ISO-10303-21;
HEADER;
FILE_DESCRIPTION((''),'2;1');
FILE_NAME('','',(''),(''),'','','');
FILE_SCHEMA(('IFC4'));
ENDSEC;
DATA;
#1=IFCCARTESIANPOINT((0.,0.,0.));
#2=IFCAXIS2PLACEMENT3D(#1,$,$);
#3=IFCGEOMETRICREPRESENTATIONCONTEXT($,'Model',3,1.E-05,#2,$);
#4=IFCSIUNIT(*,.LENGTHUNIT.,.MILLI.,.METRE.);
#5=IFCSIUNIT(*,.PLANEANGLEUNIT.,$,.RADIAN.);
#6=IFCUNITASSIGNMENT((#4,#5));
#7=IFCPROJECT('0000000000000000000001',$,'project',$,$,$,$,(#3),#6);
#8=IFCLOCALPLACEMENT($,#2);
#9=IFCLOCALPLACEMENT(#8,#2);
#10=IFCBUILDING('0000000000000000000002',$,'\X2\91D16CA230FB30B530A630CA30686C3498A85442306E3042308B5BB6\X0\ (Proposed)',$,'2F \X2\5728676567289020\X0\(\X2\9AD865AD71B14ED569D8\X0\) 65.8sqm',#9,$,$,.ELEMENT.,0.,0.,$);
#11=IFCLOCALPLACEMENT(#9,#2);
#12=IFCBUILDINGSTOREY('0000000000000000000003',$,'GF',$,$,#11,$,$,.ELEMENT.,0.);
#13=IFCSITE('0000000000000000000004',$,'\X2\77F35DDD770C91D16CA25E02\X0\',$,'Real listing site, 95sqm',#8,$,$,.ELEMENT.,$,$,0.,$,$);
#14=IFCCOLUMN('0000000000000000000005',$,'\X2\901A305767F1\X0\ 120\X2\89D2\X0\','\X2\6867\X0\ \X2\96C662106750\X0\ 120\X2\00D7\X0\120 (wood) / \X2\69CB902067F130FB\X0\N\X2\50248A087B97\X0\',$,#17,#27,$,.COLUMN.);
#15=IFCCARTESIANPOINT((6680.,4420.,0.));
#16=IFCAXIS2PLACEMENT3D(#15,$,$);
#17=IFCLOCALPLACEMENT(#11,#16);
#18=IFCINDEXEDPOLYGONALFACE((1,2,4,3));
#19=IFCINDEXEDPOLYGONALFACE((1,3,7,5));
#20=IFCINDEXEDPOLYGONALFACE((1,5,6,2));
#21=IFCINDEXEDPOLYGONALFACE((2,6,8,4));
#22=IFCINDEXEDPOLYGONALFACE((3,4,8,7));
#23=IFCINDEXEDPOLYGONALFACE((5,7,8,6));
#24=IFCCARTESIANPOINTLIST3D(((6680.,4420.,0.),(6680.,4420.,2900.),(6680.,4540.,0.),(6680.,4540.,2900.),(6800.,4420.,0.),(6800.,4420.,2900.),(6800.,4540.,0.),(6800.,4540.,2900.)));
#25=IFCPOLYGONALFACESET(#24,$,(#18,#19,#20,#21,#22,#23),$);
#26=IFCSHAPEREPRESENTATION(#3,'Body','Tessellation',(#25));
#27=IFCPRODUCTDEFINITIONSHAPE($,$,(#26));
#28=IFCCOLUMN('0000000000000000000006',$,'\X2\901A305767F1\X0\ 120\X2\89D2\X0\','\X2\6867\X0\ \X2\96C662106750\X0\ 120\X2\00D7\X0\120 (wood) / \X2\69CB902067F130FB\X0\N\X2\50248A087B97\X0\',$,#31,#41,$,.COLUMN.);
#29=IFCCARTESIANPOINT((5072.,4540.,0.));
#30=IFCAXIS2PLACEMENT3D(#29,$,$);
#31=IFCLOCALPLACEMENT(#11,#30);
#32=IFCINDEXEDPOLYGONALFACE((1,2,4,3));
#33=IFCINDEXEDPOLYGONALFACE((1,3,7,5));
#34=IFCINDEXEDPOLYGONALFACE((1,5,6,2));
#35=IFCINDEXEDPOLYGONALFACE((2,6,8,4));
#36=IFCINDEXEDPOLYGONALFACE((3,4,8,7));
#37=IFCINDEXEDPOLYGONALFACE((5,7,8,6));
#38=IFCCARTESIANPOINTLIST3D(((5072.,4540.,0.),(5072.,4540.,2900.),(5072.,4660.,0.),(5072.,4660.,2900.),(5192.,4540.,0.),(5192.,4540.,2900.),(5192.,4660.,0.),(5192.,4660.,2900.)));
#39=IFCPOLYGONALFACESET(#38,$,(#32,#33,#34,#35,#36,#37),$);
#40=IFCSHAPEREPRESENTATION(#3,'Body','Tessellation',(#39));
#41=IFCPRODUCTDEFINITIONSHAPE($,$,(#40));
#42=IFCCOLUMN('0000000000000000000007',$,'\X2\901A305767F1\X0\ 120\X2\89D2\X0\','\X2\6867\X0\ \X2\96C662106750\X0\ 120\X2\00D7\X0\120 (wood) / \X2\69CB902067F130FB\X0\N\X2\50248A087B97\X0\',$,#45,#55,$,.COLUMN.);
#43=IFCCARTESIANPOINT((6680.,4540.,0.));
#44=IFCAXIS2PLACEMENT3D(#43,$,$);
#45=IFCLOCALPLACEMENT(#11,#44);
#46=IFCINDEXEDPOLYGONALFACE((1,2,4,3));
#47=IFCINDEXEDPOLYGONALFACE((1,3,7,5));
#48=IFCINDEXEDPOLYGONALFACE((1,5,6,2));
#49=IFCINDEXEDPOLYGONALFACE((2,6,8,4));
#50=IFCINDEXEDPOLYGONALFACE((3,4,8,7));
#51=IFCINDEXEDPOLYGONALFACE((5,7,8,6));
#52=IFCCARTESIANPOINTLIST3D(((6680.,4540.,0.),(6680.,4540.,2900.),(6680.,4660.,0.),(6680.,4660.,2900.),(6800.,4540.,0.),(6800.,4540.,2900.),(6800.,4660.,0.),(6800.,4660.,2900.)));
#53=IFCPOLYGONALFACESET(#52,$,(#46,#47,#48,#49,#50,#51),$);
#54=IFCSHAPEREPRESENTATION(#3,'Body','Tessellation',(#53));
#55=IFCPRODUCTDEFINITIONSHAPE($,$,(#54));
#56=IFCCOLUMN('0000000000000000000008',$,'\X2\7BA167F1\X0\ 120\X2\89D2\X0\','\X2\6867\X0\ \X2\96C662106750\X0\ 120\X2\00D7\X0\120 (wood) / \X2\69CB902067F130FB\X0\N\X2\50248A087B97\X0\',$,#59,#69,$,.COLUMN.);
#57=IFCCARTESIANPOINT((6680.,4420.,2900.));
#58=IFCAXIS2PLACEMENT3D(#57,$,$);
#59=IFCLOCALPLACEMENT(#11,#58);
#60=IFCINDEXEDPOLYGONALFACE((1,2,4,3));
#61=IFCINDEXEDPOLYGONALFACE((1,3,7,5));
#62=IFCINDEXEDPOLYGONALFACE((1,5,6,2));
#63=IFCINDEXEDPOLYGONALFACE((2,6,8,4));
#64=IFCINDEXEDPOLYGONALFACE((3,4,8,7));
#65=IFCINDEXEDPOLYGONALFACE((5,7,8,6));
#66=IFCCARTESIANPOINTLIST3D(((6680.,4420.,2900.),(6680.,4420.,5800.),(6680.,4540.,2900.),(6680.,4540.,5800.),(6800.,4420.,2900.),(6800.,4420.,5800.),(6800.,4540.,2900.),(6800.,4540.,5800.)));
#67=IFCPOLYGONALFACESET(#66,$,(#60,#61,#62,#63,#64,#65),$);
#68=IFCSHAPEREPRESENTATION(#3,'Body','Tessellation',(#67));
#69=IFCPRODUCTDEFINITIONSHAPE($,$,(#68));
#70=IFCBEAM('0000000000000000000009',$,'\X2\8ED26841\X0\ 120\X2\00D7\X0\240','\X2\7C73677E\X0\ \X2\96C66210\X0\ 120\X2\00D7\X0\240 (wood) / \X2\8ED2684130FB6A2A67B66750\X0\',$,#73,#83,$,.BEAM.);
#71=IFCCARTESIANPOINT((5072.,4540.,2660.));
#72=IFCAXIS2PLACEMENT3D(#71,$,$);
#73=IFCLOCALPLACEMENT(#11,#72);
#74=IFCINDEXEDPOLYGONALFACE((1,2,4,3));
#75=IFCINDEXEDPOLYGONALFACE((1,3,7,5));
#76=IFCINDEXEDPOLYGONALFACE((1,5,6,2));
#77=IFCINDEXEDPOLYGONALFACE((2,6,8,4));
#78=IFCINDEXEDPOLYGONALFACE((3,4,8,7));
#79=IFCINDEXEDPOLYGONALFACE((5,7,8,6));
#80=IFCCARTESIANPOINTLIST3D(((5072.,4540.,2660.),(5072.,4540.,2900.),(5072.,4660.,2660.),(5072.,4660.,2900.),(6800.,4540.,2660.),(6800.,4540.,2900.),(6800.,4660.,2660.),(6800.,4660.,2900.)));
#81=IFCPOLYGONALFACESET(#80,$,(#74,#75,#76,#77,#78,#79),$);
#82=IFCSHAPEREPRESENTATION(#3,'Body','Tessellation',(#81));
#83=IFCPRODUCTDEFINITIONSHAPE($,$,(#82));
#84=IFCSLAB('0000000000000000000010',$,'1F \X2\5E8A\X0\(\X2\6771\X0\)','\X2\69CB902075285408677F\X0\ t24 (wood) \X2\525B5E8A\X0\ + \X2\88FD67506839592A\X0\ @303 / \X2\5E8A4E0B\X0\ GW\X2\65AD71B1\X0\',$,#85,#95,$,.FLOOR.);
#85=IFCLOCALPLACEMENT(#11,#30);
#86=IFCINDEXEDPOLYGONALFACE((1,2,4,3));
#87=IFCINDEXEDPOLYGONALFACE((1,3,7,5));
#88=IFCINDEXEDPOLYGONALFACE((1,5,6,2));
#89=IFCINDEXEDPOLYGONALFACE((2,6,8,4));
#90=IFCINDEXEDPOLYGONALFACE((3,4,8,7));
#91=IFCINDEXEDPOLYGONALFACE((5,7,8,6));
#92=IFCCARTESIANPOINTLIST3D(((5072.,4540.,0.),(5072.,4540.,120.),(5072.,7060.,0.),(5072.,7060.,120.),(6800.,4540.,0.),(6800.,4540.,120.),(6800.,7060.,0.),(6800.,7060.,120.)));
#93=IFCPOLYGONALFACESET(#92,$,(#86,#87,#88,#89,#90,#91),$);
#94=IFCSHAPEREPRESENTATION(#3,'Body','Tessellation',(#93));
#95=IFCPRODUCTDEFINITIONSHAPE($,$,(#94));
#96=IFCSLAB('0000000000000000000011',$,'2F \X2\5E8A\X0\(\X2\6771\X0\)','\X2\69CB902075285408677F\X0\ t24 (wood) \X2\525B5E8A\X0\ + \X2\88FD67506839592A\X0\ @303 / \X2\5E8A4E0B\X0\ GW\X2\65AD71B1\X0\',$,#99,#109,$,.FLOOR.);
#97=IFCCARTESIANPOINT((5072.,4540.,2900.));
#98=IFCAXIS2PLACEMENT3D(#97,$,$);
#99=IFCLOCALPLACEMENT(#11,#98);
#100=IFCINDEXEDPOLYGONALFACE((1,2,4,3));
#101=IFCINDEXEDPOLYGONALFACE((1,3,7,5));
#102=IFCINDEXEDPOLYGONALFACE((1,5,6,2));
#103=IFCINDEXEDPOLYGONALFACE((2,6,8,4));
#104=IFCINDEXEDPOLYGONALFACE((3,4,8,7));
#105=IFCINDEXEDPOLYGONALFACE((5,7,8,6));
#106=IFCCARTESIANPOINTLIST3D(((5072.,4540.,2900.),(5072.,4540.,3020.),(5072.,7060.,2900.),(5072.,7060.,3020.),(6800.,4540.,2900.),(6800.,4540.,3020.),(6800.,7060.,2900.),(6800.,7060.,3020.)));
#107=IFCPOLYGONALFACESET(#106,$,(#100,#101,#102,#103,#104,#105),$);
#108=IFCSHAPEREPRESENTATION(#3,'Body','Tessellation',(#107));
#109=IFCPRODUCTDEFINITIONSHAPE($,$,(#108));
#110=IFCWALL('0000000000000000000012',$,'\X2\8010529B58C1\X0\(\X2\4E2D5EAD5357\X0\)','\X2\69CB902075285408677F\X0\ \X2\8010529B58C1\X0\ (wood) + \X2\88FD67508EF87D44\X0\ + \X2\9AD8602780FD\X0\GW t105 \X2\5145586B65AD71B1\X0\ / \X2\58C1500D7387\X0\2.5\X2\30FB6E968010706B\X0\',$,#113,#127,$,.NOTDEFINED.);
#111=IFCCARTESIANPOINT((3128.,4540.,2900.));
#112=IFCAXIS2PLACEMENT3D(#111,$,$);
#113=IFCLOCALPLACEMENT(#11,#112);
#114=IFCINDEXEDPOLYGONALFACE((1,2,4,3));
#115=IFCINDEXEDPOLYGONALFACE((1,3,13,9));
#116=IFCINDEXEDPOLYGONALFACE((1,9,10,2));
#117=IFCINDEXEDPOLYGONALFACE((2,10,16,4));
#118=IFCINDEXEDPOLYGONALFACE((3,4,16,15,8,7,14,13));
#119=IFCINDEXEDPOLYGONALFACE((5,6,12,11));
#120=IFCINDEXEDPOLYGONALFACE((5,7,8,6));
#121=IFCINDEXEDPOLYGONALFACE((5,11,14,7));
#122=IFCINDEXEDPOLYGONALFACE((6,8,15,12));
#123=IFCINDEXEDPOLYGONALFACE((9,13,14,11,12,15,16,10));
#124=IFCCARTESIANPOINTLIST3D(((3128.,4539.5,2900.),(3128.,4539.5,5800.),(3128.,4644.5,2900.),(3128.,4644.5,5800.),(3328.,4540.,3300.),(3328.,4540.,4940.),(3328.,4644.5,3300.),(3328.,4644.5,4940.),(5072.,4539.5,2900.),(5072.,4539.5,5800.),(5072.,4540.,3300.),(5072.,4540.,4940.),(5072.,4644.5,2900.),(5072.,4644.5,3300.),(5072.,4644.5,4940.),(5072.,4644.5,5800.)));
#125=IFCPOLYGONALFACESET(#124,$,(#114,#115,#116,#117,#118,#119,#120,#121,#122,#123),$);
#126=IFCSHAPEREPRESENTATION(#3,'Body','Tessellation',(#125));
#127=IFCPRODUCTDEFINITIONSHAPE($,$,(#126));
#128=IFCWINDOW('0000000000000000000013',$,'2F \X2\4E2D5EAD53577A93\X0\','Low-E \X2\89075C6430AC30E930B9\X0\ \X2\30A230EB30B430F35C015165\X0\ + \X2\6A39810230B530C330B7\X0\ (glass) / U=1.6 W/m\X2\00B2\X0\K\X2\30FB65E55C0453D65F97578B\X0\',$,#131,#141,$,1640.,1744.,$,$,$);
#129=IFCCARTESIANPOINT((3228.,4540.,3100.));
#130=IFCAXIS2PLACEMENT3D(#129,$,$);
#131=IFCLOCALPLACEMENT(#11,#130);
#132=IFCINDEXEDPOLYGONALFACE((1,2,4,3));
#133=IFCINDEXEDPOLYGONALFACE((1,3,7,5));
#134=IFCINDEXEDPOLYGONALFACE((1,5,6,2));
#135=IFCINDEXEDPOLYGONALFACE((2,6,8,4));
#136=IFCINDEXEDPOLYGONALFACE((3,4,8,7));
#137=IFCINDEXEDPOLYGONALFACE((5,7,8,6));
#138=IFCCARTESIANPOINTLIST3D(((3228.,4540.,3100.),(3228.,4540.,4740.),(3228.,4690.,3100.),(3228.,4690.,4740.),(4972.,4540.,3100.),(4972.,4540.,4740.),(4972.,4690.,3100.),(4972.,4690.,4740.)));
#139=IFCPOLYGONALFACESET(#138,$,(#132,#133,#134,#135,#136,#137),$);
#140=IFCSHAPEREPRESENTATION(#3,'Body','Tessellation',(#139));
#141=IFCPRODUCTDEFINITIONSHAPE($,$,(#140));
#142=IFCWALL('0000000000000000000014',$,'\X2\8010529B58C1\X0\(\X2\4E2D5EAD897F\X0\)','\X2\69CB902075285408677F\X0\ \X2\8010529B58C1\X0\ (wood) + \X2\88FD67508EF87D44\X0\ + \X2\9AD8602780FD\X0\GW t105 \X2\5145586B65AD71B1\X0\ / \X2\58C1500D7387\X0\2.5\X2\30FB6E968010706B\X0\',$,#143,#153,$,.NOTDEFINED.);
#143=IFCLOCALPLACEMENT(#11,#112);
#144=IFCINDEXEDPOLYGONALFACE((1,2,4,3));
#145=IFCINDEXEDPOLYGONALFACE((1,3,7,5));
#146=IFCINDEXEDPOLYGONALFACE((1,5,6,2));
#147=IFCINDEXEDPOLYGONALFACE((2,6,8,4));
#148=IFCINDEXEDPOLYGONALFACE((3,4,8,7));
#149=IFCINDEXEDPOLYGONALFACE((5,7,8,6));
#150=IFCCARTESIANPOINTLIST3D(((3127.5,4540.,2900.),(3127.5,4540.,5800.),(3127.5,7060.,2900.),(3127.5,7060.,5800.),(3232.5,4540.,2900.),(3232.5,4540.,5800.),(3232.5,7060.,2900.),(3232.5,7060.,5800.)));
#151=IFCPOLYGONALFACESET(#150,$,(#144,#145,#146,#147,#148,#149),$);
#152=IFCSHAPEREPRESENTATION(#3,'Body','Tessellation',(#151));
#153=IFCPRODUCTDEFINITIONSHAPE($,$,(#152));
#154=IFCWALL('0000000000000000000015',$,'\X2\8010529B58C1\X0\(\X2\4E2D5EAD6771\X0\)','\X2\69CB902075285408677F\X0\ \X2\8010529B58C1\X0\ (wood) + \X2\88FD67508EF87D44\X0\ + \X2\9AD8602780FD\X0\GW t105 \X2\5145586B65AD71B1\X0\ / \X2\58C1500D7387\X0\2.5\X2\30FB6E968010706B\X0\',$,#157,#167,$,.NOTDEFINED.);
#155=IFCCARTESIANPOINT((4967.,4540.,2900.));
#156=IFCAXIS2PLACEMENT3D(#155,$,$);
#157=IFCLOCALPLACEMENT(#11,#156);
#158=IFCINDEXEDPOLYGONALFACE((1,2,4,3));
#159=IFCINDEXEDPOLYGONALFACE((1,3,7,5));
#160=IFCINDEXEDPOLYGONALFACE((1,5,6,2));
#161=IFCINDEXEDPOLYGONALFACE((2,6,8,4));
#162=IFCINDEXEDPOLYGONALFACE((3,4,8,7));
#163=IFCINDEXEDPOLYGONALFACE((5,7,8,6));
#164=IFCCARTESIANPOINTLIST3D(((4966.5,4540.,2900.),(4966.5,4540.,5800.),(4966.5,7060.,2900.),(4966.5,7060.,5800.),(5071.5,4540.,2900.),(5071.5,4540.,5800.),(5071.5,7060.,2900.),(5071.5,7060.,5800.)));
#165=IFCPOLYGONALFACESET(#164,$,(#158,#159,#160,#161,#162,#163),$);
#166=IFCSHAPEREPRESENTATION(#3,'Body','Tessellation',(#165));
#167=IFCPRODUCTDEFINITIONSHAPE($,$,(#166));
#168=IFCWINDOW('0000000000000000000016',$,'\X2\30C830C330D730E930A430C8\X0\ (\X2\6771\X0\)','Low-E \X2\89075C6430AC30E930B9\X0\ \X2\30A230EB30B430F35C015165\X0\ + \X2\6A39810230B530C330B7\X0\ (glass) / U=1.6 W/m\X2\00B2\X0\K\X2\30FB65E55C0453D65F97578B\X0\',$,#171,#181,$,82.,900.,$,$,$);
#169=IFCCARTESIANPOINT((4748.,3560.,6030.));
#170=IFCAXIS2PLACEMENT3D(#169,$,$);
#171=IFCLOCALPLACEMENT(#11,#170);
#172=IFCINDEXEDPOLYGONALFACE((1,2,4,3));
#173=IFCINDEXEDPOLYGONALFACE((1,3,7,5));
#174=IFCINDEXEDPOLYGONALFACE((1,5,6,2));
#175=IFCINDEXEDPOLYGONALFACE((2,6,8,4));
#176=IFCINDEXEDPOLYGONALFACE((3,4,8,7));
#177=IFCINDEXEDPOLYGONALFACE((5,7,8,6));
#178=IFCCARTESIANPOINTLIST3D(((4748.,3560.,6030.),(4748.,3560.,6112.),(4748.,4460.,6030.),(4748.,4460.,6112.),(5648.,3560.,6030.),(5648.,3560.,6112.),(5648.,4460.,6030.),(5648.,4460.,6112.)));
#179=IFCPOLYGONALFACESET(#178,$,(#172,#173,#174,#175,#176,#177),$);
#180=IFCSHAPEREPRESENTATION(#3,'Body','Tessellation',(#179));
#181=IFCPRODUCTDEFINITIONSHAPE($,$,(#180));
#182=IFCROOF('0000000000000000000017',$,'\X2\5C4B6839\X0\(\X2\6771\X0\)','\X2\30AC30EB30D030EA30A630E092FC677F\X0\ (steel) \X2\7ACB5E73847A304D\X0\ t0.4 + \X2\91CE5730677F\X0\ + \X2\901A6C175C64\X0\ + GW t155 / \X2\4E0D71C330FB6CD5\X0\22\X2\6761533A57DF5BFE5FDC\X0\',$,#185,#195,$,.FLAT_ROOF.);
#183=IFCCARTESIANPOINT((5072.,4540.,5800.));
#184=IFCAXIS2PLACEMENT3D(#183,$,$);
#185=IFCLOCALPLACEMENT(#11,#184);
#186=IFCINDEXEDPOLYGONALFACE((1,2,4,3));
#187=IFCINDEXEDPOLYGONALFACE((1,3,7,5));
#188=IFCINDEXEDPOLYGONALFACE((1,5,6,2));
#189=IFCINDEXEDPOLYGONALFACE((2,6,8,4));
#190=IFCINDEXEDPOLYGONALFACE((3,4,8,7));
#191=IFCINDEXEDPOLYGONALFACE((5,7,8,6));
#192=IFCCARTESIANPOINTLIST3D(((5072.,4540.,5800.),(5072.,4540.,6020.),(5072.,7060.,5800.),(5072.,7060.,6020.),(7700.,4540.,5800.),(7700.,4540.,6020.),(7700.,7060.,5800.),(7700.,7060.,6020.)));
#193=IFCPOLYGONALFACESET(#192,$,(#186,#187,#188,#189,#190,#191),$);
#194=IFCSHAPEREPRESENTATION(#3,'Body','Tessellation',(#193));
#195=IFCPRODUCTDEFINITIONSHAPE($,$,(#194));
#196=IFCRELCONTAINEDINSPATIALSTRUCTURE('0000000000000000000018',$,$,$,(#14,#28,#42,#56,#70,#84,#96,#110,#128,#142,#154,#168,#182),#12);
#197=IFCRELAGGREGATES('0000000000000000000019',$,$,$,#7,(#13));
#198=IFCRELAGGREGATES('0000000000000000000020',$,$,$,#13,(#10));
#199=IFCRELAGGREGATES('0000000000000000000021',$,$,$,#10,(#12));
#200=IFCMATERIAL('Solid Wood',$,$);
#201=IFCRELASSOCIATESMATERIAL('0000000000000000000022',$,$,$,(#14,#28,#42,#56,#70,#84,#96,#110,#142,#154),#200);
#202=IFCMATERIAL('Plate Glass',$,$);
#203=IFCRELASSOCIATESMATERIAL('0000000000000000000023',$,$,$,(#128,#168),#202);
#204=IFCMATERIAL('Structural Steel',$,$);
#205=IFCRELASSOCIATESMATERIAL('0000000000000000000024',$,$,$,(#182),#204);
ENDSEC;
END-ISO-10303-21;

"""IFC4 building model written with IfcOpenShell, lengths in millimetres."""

from ifc_helpers import new_model, si_unit, frame, frame_2d, origin, place, context, project, spatial, rectangle, extrude, material, element, fill, save


model = new_model("IFC4")

# Units and contexts
model_context = context("Model", 3, precision=1e-05, world=origin())
ifc_project = project(units=[si_unit("LENGTHUNIT", "METRE", prefix="MILLI"), si_unit("PLANEANGLEUNIT", "RADIAN")], contexts=[model_context])

# Site, building, storey
site_placement = place(None, origin())
site = spatial("IfcSite", under=ifc_project, at=site_placement, Name="石川県金沢市", ObjectType="Real listing site, 95sqm", CompositionType="ELEMENT", RefElevation=0.0)
building_placement = place(site_placement, origin())
building = spatial("IfcBuilding", under=site, at=building_placement, Name="金沢・サウナと水風呂のある家 (Proposed)", ObjectType="2F 在来木造(高断熱仕様) 65.8sqm", CompositionType="ELEMENT", ElevationOfRefHeight=0.0, ElevationOfTerrain=0.0)
storey_placement = place(building_placement, origin())
storey = spatial("IfcBuildingStorey", under=building, at=storey_placement, Name="GF", CompositionType="ELEMENT", Elevation=0.0)

# Columns
ifc_material_1 = material(Name="Solid Wood")
column_1_placement = place(storey_placement, frame((6680.0, 4420.0, 0.0)))
element("IfcColumn", 1, at=column_1_placement, inside=storey, material=ifc_material_1, Name="通し柱 120角", Description="桧 集成材 120×120 (wood) / 構造柱・N値計算", PredefinedType="COLUMN", context=model_context, shape_type="SweptSolid", body=[
    extrude(rectangle(XDim=120.0, YDim=120.0, at=frame_2d((60.0, 60.0))), frame((6680.0, 4420.0, 0.0)), (0.0, 0.0, 1.0), 2900.0),
])
column_2_placement = place(storey_placement, frame((5072.0, 4540.0, 0.0)))
element("IfcColumn", 2, at=column_2_placement, inside=storey, material=ifc_material_1, Name="通し柱 120角", Description="桧 集成材 120×120 (wood) / 構造柱・N値計算", PredefinedType="COLUMN", context=model_context, shape_type="SweptSolid", body=[
    extrude(rectangle(XDim=120.0, YDim=120.0, at=frame_2d((60.0, 60.0))), frame((5072.0, 4540.0, 0.0)), (0.0, 0.0, 1.0), 2900.0),
])
column_3_placement = place(storey_placement, frame((6680.0, 4540.0, 0.0)))
element("IfcColumn", 3, at=column_3_placement, inside=storey, material=ifc_material_1, Name="通し柱 120角", Description="桧 集成材 120×120 (wood) / 構造柱・N値計算", PredefinedType="COLUMN", context=model_context, shape_type="SweptSolid", body=[
    extrude(rectangle(XDim=120.0, YDim=120.0, at=frame_2d((60.0, 60.0))), frame((6680.0, 4540.0, 0.0)), (0.0, 0.0, 1.0), 2900.0),
])
column_4_placement = place(storey_placement, frame((6680.0, 4420.0, 2900.0)))
element("IfcColumn", 4, at=column_4_placement, inside=storey, material=ifc_material_1, Name="管柱 120角", Description="桧 集成材 120×120 (wood) / 構造柱・N値計算", PredefinedType="COLUMN", context=model_context, shape_type="SweptSolid", body=[
    extrude(rectangle(XDim=120.0, YDim=120.0, at=frame_2d((60.0, 60.0))), frame((6680.0, 4420.0, 2900.0)), (0.0, 0.0, 1.0), 2900.0),
])

# Beam
beam_1_placement = place(storey_placement, frame((5072.0, 4540.0, 2660.0)))
element("IfcBeam", 5, at=beam_1_placement, inside=storey, material=ifc_material_1, Name="軒桁 120×240", Description="米松 集成 120×240 (wood) / 軒桁・横架材", PredefinedType="BEAM", context=model_context, shape_type="SweptSolid", body=[
    extrude(rectangle(XDim=1728.0, YDim=120.0, at=frame_2d((864.0, 60.0))), frame((5072.0, 4540.0, 2660.0)), (0.0, 0.0, 1.0), 240.0),
])

# Slabs
slab_1_placement = place(storey_placement, frame((5072.0, 4540.0, 0.0)))
element("IfcSlab", 6, at=slab_1_placement, inside=storey, material=ifc_material_1, Name="1F 床(東)", Description="構造用合板 t24 (wood) 剛床 + 製材根太 @303 / 床下 GW断熱", PredefinedType="FLOOR", context=model_context, shape_type="SweptSolid", body=[
    extrude(rectangle(XDim=1728.0, YDim=2520.0, at=frame_2d((864.0, 1260.0))), frame((5072.0, 4540.0, 0.0)), (0.0, 0.0, 1.0), 120.0),
])
slab_2_placement = place(storey_placement, frame((5072.0, 4540.0, 2900.0)))
element("IfcSlab", 7, at=slab_2_placement, inside=storey, material=ifc_material_1, Name="2F 床(東)", Description="構造用合板 t24 (wood) 剛床 + 製材根太 @303 / 床下 GW断熱", PredefinedType="FLOOR", context=model_context, shape_type="SweptSolid", body=[
    extrude(rectangle(XDim=1728.0, YDim=2520.0, at=frame_2d((864.0, 1260.0))), frame((5072.0, 4540.0, 2900.0)), (0.0, 0.0, 1.0), 120.0),
])

# Wall, opening, window
wall_1_placement = place(storey_placement, frame((3128.0, 4540.0, 2900.0)))
wall_1 = element("IfcWall", 8, at=wall_1_placement, inside=storey, material=ifc_material_1, Name="耐力壁(中庭南)", Description="構造用合板 耐力壁 (wood) + 製材軸組 + 高性能GW t105 充填断熱 / 壁倍率2.5・準耐火", PredefinedType="NOTDEFINED", context=model_context, shape_type="SweptSolid", body=[
    extrude(rectangle(XDim=1944.0, YDim=105.0, at=frame_2d((972.0, 52.0))), frame((3128.0, 4540.0, 2900.0)), (0.0, 0.0, 1.0), 2900.0),
])
opening_placement = place(storey_placement, frame((3228.0, 4540.0, 3100.0)))
opening = element("IfcOpeningElement", 9, at=opening_placement, cuts=wall_1, PredefinedType="NOTDEFINED", context=model_context, shape_type="SweptSolid", body=[
    extrude(rectangle(XDim=1744.0, YDim=150.0, at=frame_2d((872.0, 75.0))), frame((3228.0, 4540.0, 3100.0)), (0.0, 0.0, 1.0), 1640.0),
])
ifc_material_2 = material(Name="Plate Glass")
window_1_placement = place(storey_placement, frame((3228.0, 4540.0, 3100.0)))
window_1 = element("IfcWindow", 10, at=window_1_placement, inside=storey, material=ifc_material_2, Name="2F 中庭南窓", Description="Low-E 複層ガラス アルゴン封入 + 樹脂サッシ (glass) / U=1.6 W/m²K・日射取得型", OverallHeight=1640.0, OverallWidth=1744.0, context=model_context, shape_type="SweptSolid", body=[
    extrude(rectangle(XDim=1744.0, YDim=150.0, at=frame_2d((872.0, 75.0))), frame((3228.0, 4540.0, 3100.0)), (0.0, 0.0, 1.0), 1640.0),
])
fill(opening, window_1)

# Walls
wall_2_placement = place(storey_placement, frame((3128.0, 4540.0, 2900.0)))
element("IfcWall", 11, at=wall_2_placement, inside=storey, material=ifc_material_1, Name="耐力壁(中庭西)", Description="構造用合板 耐力壁 (wood) + 製材軸組 + 高性能GW t105 充填断熱 / 壁倍率2.5・準耐火", PredefinedType="NOTDEFINED", context=model_context, shape_type="SweptSolid", body=[
    extrude(rectangle(XDim=105.0, YDim=2520.0, at=frame_2d((52.0, 1260.0))), frame((3128.0, 4540.0, 2900.0)), (0.0, 0.0, 1.0), 2900.0),
])
wall_3_placement = place(storey_placement, frame((4967.0, 4540.0, 2900.0)))
element("IfcWall", 12, at=wall_3_placement, inside=storey, material=ifc_material_1, Name="耐力壁(中庭東)", Description="構造用合板 耐力壁 (wood) + 製材軸組 + 高性能GW t105 充填断熱 / 壁倍率2.5・準耐火", PredefinedType="NOTDEFINED", context=model_context, shape_type="SweptSolid", body=[
    extrude(rectangle(XDim=105.0, YDim=2520.0, at=frame_2d((52.0, 1260.0))), frame((4967.0, 4540.0, 2900.0)), (0.0, 0.0, 1.0), 2900.0),
])

# Window
window_2_placement = place(storey_placement, frame((4748.0, 3560.0, 6030.0)))
element("IfcWindow", 13, at=window_2_placement, inside=storey, material=ifc_material_2, Name="トップライト (東)", Description="Low-E 複層ガラス アルゴン封入 + 樹脂サッシ (glass) / U=1.6 W/m²K・日射取得型", OverallHeight=82.0, OverallWidth=900.0, context=model_context, shape_type="SweptSolid", body=[
    extrude(rectangle(XDim=900.0, YDim=900.0, at=frame_2d((450.0, 450.0))), frame((4748.0, 3560.0, 6030.0)), (0.0, 0.0, 1.0), 82.0),
])

# Roof
ifc_material_3 = material(Name="Structural Steel")
for number, where, name in (
    (14, (5072.0, 4540.0, 5800.0), "屋根(東)"),
):
    element("IfcRoof", number, at=place(storey_placement, frame(where)), inside=storey, material=ifc_material_3, Name=name, Description="ガルバリウム鋼板 (steel) 立平葺き t0.4 + 野地板 + 通気層 + GW t155 / 不燃・法22条区域対応", PredefinedType="FLAT_ROOF", context=model_context, shape_type="SweptSolid", body=[
        extrude(rectangle(XDim=2628.0, YDim=2520.0, at=frame_2d((1314.0, 1260.0))), frame((5072.0, 4540.0, 5800.0)), (0.0, 0.0, 1.0), 220.0),
    ])

save(model, "model.ifc")
